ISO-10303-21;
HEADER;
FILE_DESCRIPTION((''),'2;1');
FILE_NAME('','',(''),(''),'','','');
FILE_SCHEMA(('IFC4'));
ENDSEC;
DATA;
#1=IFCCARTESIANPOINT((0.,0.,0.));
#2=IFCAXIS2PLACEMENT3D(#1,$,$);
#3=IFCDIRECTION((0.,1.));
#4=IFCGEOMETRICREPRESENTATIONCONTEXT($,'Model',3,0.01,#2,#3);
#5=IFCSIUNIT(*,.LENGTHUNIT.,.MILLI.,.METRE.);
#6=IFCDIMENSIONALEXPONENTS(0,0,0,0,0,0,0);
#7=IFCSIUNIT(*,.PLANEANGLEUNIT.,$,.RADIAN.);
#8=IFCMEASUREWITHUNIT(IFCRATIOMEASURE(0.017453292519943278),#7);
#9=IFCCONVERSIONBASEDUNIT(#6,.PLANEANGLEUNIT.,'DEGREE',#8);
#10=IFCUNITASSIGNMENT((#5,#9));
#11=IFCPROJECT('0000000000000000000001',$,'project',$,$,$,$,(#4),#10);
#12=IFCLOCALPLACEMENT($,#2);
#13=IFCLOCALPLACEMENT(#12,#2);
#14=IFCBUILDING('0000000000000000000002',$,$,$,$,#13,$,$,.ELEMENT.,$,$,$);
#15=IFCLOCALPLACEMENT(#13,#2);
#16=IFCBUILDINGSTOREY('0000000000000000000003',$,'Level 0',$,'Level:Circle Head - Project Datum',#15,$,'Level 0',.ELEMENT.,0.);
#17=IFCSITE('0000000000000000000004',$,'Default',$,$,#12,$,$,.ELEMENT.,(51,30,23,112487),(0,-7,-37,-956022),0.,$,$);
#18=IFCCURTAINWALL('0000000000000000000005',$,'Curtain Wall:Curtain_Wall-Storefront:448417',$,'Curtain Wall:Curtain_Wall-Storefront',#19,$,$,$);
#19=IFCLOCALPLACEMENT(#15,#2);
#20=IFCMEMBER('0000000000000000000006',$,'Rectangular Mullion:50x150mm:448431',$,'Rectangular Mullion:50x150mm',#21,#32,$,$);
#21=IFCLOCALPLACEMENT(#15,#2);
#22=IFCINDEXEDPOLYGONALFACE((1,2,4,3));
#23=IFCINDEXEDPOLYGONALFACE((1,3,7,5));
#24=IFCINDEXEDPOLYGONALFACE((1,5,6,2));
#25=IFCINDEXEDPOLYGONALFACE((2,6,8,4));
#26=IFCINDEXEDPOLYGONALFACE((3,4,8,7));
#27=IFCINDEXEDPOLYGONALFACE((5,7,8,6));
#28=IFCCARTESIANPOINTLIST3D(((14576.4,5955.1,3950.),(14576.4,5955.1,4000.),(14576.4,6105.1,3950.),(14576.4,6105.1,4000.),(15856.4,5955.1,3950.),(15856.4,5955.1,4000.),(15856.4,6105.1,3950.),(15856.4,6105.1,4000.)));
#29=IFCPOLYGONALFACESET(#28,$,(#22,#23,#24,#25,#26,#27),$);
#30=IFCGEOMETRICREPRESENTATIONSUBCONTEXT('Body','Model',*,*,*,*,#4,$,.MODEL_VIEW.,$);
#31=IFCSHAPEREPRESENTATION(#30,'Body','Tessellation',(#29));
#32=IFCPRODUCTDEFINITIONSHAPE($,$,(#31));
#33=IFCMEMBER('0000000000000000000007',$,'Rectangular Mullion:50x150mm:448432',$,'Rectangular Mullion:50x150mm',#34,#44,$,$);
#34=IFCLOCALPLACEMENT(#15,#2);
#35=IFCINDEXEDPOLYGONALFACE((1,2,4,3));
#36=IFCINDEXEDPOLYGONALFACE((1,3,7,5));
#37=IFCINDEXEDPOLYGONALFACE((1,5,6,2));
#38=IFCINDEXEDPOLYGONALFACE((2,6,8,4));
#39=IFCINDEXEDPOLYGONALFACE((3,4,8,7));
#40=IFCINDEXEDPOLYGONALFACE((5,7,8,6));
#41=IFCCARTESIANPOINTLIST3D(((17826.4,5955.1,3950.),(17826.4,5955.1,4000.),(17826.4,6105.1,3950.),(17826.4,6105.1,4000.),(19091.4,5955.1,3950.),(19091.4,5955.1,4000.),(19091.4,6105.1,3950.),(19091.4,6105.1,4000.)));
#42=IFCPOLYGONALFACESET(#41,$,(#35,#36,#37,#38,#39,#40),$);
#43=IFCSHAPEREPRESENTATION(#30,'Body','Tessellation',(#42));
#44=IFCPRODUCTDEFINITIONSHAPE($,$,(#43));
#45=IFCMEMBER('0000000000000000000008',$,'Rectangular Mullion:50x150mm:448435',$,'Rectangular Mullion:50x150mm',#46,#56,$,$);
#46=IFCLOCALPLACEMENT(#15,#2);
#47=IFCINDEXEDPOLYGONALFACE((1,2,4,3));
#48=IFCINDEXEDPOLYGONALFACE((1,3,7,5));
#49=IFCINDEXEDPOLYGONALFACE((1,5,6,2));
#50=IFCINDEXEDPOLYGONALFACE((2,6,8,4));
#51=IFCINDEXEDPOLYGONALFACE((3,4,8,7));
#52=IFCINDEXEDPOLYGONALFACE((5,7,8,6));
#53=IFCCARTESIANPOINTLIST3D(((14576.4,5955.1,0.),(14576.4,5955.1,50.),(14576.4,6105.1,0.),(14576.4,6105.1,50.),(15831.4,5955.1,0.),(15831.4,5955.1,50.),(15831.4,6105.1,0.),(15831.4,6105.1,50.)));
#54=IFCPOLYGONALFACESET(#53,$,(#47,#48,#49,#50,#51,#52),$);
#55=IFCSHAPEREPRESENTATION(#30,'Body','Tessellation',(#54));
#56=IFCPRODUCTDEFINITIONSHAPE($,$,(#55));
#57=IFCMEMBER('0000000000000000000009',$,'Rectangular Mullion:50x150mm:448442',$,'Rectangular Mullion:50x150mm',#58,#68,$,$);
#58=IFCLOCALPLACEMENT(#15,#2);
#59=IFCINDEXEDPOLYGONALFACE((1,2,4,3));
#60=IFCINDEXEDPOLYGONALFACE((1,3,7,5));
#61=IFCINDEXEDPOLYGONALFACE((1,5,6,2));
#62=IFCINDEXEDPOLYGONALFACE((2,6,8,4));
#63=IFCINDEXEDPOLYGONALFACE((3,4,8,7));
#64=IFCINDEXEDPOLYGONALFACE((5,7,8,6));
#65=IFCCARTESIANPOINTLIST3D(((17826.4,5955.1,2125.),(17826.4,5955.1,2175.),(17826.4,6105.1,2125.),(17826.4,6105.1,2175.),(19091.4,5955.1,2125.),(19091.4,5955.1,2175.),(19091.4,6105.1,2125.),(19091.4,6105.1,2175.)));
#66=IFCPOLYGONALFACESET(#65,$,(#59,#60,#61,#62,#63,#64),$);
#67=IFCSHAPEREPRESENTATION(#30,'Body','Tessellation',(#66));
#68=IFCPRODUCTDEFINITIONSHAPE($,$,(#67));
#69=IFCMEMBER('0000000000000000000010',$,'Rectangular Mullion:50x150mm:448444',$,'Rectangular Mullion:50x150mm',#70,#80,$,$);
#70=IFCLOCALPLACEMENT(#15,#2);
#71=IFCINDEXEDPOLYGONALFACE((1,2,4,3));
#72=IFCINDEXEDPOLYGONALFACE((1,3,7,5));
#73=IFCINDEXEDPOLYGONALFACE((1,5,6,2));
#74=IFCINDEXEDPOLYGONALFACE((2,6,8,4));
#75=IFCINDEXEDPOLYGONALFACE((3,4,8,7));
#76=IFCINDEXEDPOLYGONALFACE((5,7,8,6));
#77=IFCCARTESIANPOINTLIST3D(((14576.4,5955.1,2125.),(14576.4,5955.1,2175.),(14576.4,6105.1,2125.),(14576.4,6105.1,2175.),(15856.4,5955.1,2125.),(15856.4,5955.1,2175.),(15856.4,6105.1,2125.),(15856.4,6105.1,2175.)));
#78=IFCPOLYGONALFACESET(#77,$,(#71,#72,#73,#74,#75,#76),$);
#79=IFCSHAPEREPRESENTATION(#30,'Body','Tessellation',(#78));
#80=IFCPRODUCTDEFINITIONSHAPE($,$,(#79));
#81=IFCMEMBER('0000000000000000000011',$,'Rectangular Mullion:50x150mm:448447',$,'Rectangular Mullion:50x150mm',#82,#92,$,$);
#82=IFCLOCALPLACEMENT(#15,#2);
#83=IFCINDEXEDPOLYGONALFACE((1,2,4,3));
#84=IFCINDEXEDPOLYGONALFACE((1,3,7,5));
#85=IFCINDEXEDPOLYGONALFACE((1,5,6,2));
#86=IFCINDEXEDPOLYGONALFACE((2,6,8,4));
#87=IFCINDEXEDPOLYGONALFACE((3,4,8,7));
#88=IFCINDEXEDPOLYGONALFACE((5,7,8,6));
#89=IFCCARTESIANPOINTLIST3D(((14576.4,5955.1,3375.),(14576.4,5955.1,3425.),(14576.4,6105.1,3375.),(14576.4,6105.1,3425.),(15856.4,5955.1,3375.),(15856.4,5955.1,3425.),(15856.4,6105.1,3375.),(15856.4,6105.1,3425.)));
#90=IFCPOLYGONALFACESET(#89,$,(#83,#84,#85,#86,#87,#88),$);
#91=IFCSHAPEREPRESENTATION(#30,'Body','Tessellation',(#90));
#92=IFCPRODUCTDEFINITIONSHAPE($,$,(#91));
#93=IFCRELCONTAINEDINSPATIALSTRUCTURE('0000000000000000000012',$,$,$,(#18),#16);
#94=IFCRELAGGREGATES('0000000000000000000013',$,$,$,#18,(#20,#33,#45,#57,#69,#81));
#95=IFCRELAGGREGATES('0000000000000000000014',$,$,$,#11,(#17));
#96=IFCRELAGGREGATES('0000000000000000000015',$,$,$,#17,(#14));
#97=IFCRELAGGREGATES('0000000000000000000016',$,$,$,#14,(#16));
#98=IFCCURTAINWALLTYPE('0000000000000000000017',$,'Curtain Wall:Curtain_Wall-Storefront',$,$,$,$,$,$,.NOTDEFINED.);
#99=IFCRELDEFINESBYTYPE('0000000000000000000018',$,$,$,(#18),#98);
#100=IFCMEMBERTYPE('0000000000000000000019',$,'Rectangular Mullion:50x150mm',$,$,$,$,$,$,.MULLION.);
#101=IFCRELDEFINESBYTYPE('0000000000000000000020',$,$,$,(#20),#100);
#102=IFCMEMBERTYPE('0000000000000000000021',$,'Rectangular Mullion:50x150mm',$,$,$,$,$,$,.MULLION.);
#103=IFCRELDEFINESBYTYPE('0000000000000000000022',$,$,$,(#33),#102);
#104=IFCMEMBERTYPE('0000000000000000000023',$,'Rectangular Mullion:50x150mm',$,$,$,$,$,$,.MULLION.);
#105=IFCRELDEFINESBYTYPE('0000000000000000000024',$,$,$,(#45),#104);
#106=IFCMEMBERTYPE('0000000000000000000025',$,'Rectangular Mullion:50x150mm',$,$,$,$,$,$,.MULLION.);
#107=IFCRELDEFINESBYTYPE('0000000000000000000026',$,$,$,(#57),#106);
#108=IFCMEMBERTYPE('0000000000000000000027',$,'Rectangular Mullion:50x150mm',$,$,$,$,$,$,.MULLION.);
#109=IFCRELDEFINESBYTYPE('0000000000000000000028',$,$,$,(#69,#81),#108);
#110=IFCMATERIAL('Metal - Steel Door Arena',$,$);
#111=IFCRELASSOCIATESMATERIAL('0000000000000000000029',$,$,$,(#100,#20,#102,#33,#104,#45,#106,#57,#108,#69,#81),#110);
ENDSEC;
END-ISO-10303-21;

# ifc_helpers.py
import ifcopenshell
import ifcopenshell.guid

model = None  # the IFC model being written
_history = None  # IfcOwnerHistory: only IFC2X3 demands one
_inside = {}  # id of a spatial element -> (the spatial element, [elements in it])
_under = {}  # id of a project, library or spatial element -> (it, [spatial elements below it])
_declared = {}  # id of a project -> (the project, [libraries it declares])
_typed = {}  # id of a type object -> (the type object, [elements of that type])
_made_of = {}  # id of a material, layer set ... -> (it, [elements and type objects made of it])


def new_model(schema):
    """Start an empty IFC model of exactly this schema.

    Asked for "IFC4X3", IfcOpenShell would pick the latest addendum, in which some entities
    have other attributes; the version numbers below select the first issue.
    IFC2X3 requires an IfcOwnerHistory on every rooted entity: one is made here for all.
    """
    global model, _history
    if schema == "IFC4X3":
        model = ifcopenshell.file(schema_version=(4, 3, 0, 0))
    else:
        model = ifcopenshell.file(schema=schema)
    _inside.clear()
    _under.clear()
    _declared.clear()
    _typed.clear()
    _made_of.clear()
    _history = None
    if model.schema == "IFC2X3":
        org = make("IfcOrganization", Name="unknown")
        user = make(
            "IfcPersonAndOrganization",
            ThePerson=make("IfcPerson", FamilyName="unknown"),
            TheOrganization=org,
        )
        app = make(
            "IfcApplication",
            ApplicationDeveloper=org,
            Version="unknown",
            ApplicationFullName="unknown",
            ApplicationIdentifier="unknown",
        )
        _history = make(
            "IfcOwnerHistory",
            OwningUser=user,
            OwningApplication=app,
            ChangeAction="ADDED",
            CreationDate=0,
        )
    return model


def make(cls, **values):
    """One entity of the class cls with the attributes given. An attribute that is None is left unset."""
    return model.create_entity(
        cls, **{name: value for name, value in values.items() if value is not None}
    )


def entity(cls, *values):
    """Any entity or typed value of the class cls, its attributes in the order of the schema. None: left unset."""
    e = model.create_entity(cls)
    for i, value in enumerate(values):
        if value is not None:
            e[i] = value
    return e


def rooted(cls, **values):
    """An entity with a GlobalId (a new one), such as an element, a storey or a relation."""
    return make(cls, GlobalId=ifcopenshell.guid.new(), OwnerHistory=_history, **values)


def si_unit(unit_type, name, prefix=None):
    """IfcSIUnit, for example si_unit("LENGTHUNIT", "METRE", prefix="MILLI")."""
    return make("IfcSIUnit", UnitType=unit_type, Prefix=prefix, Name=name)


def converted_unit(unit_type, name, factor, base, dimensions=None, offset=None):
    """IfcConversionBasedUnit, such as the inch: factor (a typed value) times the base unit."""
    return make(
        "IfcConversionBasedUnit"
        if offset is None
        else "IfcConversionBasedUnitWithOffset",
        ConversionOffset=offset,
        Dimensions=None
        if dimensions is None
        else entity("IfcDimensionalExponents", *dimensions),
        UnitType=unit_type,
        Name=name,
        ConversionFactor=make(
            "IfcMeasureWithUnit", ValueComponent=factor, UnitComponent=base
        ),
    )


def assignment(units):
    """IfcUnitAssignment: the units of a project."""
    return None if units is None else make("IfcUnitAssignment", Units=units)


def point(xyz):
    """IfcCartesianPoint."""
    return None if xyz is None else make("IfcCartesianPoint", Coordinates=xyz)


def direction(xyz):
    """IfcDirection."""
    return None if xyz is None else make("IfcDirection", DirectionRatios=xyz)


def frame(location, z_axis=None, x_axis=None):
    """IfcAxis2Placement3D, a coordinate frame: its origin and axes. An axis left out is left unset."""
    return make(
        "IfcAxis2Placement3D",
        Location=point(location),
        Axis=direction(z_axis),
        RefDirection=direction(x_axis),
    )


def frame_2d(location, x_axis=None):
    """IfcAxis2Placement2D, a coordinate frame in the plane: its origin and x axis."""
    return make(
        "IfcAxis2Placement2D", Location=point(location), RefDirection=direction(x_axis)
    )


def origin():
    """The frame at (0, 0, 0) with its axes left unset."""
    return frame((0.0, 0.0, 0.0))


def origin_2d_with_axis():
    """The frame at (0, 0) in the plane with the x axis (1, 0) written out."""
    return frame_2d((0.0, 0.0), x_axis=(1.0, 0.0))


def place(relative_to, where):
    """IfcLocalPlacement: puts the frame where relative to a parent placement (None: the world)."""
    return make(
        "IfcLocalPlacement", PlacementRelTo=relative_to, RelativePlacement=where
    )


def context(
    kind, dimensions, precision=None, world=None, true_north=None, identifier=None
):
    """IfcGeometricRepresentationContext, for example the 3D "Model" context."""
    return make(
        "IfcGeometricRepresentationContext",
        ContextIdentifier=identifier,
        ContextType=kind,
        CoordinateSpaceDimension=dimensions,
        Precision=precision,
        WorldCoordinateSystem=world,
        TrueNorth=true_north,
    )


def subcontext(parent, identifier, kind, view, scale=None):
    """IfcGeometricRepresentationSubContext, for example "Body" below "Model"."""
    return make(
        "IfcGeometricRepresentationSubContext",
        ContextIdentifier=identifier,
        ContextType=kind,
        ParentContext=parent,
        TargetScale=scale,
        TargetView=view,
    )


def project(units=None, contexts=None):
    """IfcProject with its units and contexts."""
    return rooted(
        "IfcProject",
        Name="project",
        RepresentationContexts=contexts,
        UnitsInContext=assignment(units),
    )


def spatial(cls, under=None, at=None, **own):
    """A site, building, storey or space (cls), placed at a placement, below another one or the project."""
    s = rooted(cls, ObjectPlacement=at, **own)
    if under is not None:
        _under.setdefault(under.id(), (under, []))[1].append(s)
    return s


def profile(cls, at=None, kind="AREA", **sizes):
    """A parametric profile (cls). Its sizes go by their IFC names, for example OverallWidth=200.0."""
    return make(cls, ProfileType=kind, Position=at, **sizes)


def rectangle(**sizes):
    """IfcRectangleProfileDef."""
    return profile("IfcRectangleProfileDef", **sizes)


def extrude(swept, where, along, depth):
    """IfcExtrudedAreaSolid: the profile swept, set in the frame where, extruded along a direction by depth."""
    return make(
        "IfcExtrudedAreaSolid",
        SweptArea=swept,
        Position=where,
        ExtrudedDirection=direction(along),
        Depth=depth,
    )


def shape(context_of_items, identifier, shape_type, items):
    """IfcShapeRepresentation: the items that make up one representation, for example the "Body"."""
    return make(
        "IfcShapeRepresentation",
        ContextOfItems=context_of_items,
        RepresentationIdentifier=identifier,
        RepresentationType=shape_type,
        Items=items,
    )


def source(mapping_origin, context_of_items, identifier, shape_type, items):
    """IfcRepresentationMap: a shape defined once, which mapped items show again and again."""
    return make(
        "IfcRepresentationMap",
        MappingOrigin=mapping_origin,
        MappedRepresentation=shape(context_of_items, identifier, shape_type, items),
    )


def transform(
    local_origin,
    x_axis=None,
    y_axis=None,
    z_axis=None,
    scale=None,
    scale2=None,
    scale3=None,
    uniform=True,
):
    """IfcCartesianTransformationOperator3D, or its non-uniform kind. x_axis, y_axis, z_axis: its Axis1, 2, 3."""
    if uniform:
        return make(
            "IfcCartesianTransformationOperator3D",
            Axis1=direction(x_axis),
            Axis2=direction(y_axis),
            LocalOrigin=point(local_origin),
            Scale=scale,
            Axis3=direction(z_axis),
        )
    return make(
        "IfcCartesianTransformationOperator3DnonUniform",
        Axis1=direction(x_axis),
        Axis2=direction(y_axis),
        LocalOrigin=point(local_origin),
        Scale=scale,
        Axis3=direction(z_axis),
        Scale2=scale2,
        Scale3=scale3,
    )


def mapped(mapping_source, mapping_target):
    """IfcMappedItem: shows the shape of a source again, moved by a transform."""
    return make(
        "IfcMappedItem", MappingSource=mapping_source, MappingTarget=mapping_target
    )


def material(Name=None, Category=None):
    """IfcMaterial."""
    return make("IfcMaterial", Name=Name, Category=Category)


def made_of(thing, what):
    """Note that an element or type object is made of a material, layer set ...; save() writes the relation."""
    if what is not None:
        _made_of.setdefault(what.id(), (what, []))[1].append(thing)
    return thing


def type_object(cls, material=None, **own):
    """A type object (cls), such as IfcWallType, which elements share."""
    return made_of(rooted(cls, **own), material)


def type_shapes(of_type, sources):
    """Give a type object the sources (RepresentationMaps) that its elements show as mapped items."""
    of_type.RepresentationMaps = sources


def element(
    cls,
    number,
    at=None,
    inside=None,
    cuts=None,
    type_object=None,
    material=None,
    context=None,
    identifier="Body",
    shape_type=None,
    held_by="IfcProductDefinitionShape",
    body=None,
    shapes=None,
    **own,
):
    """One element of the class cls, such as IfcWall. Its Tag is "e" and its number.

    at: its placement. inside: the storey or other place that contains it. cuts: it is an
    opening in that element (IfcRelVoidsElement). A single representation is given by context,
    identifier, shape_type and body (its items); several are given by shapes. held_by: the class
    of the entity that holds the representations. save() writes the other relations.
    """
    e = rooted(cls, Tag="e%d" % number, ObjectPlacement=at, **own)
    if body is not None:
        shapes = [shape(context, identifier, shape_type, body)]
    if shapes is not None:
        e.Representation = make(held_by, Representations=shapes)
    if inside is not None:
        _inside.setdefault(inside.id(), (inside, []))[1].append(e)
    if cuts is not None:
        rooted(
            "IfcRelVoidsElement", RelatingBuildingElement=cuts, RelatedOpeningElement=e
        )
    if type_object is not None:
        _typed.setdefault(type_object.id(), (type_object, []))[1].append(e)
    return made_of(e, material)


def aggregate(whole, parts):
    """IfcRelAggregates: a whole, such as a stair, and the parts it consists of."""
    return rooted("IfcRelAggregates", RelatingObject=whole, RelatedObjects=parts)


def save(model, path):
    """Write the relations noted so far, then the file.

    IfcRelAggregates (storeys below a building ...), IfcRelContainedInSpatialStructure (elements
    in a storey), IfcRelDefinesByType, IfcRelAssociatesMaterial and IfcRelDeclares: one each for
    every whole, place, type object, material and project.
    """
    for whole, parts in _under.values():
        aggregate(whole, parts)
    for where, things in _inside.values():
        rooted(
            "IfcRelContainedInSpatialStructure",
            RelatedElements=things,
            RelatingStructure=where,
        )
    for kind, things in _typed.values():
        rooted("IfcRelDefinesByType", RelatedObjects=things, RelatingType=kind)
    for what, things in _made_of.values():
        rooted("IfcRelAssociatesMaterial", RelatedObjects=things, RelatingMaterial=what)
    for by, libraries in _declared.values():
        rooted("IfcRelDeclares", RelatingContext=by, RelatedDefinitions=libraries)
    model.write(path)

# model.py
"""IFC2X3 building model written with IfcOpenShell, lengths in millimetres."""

from ifc_helpers import new_model, entity, si_unit, converted_unit, direction, frame, origin, origin_2d_with_axis, place, context, subcontext, project, spatial, rectangle, extrude, source, transform, mapped, material, type_object, type_shapes, element, aggregate, save


model = new_model("IFC2X3")

# Units and contexts
model_context = context("Model", 3, precision=0.01, world=origin(), true_north=direction((0.0, 1.0)))
body_context = subcontext(model_context, "Body", "Model", "MODEL_VIEW")
ifc_project = project(units=[si_unit("LENGTHUNIT", "METRE", prefix="MILLI"), converted_unit("PLANEANGLEUNIT", "DEGREE", entity("IfcRatioMeasure", 0.017453292519943278), si_unit("PLANEANGLEUNIT", "RADIAN"), dimensions=[0, 0, 0, 0, 0, 0, 0])], contexts=[model_context])

# Site, building, storey
site_placement = place(None, origin())
site = spatial("IfcSite", under=ifc_project, at=site_placement, Name="Default", CompositionType="ELEMENT", RefLatitude=(51, 30, 23, 112487), RefLongitude=(0, -7, -37, -956022), RefElevation=0.0)
building_placement = place(site_placement, origin())
building = spatial("IfcBuilding", under=site, at=building_placement, CompositionType="ELEMENT")
storey_placement = place(building_placement, origin())
storey = spatial("IfcBuildingStorey", under=building, at=storey_placement, Name="Level 0", ObjectType="Level:Circle Head - Project Datum", LongName="Level 0", CompositionType="ELEMENT", Elevation=0.0)

# Curtain wall
curtain_wall_type = type_object("IfcCurtainWallType", Name="Curtain Wall:Curtain_Wall-Storefront", PredefinedType="NOTDEFINED")
curtain_wall_1_placement = place(storey_placement, origin())
curtain_wall_1 = element("IfcCurtainWall", 1, at=curtain_wall_1_placement, inside=storey, type_object=curtain_wall_type, Name="Curtain Wall:Curtain_Wall-Storefront:448417", ObjectType="Curtain Wall:Curtain_Wall-Storefront")
ifc_material_1 = material(Name="Metal - Steel Door Arena")

# Members
member_type_1 = type_object("IfcMemberType", Name="Rectangular Mullion:50x150mm", PredefinedType="MULLION", material=ifc_material_1)
shared_shape_1 = source(origin(), body_context, "Body", "SweptSolid", [
    extrude(rectangle(XDim=150.0, YDim=50.0, at=origin_2d_with_axis()), frame((-25.0, 0.0, -1280.0), z_axis=(0.0, 0.0, 1.0), x_axis=(0.0, -1.0, 0.0)), (0.0, 0.0, 1.0), 1280.0),
])
type_shapes(member_type_1, [shared_shape_1])
member_1_placement = place(curtain_wall_1_placement, frame((14576.4, 6030.1, 4000.0), z_axis=(-1.0, 0.0, 0.0), x_axis=(0.0, 0.0, 1.0)))
member_1 = element("IfcMember", 2, at=member_1_placement, type_object=member_type_1, material=ifc_material_1, Name="Rectangular Mullion:50x150mm:448431", ObjectType="Rectangular Mullion:50x150mm", context=body_context, shape_type="MappedRepresentation", body=[
    mapped(shared_shape_1, transform((0.0, 0.0, 0.0), scale=1.0)),
])
member_type_2 = type_object("IfcMemberType", Name="Rectangular Mullion:50x150mm", PredefinedType="MULLION", material=ifc_material_1)
shared_shape_2 = source(origin(), body_context, "Body", "SweptSolid", [
    extrude(rectangle(XDim=150.0, YDim=50.0, at=origin_2d_with_axis()), frame((-25.0, 0.0, -1265.0), z_axis=(0.0, 0.0, 1.0), x_axis=(0.0, -1.0, 0.0)), (0.0, 0.0, 1.0), 1265.0),
])
type_shapes(member_type_2, [shared_shape_2])
member_2_placement = place(curtain_wall_1_placement, frame((17826.4, 6030.1, 4000.0), z_axis=(-1.0, 0.0, 0.0), x_axis=(0.0, 0.0, 1.0)))
member_2 = element("IfcMember", 3, at=member_2_placement, type_object=member_type_2, material=ifc_material_1, Name="Rectangular Mullion:50x150mm:448432", ObjectType="Rectangular Mullion:50x150mm", context=body_context, shape_type="MappedRepresentation", body=[
    mapped(shared_shape_2, transform((0.0, 0.0, 0.0), scale=1.0)),
])
member_type_3 = type_object("IfcMemberType", Name="Rectangular Mullion:50x150mm", PredefinedType="MULLION", material=ifc_material_1)
shared_shape_3 = source(origin(), body_context, "Body", "SweptSolid", [
    extrude(rectangle(XDim=150.0, YDim=50.0, at=origin_2d_with_axis()), frame((-25.0, 0.0, -1255.0), z_axis=(0.0, 0.0, 1.0), x_axis=(0.0, -1.0, 0.0)), (0.0, 0.0, 1.0), 1255.0),
])
type_shapes(member_type_3, [shared_shape_3])
member_3_placement = place(curtain_wall_1_placement, frame((15831.4, 6030.1, 0.0), z_axis=(1.0, 0.0, 0.0), x_axis=(0.0, 0.0, -1.0)))
member_3 = element("IfcMember", 4, at=member_3_placement, type_object=member_type_3, material=ifc_material_1, Name="Rectangular Mullion:50x150mm:448435", ObjectType="Rectangular Mullion:50x150mm", context=body_context, shape_type="MappedRepresentation", body=[
    mapped(shared_shape_3, transform((0.0, 0.0, 0.0), scale=1.0)),
])
member_type_4 = type_object("IfcMemberType", Name="Rectangular Mullion:50x150mm", PredefinedType="MULLION", material=ifc_material_1)
shared_shape_4 = source(origin(), body_context, "Body", "SweptSolid", [
    extrude(rectangle(XDim=150.0, YDim=50.0, at=origin_2d_with_axis()), frame((0.0, 0.0, -1265.0), z_axis=(0.0, 0.0, 1.0), x_axis=(0.0, -1.0, 0.0)), (0.0, 0.0, 1.0), 1265.0),
])
type_shapes(member_type_4, [shared_shape_4])
member_4_placement = place(curtain_wall_1_placement, frame((17826.4, 6030.1, 2150.0), z_axis=(-1.0, 0.0, 0.0), x_axis=(0.0, 0.0, 1.0)))
member_4 = element("IfcMember", 5, at=member_4_placement, type_object=member_type_4, material=ifc_material_1, Name="Rectangular Mullion:50x150mm:448442", ObjectType="Rectangular Mullion:50x150mm", context=body_context, shape_type="MappedRepresentation", body=[
    mapped(shared_shape_4, transform((0.0, 0.0, 0.0), scale=1.0)),
])
member_type_5 = type_object("IfcMemberType", Name="Rectangular Mullion:50x150mm", PredefinedType="MULLION", material=ifc_material_1)
shared_shape_5 = source(origin(), body_context, "Body", "SweptSolid", [
    extrude(rectangle(XDim=150.0, YDim=50.0, at=origin_2d_with_axis()), frame((0.0, 0.0, -1280.0), z_axis=(0.0, 0.0, 1.0), x_axis=(0.0, -1.0, 0.0)), (0.0, 0.0, 1.0), 1280.0),
])
type_shapes(member_type_5, [shared_shape_5])
member_5_placement = place(curtain_wall_1_placement, frame((14576.4, 6030.1, 2150.0), z_axis=(-1.0, 0.0, 0.0), x_axis=(0.0, 0.0, 1.0)))
member_5 = element("IfcMember", 6, at=member_5_placement, type_object=member_type_5, material=ifc_material_1, Name="Rectangular Mullion:50x150mm:448444", ObjectType="Rectangular Mullion:50x150mm", context=body_context, shape_type="MappedRepresentation", body=[
    mapped(shared_shape_5, transform((0.0, 0.0, 0.0), scale=1.0)),
])
member_6_placement = place(curtain_wall_1_placement, frame((14576.4, 6030.1, 3400.0), z_axis=(-1.0, 0.0, 0.0), x_axis=(0.0, 0.0, 1.0)))
member_6 = element("IfcMember", 7, at=member_6_placement, type_object=member_type_5, material=ifc_material_1, Name="Rectangular Mullion:50x150mm:448447", ObjectType="Rectangular Mullion:50x150mm", context=body_context, shape_type="MappedRepresentation", body=[
    mapped(shared_shape_5, transform((0.0, 0.0, 0.0), scale=1.0)),
])

aggregate(curtain_wall_1, [member_1, member_2, member_3, member_4, member_5, member_6])

save(model, "model.ifc")
